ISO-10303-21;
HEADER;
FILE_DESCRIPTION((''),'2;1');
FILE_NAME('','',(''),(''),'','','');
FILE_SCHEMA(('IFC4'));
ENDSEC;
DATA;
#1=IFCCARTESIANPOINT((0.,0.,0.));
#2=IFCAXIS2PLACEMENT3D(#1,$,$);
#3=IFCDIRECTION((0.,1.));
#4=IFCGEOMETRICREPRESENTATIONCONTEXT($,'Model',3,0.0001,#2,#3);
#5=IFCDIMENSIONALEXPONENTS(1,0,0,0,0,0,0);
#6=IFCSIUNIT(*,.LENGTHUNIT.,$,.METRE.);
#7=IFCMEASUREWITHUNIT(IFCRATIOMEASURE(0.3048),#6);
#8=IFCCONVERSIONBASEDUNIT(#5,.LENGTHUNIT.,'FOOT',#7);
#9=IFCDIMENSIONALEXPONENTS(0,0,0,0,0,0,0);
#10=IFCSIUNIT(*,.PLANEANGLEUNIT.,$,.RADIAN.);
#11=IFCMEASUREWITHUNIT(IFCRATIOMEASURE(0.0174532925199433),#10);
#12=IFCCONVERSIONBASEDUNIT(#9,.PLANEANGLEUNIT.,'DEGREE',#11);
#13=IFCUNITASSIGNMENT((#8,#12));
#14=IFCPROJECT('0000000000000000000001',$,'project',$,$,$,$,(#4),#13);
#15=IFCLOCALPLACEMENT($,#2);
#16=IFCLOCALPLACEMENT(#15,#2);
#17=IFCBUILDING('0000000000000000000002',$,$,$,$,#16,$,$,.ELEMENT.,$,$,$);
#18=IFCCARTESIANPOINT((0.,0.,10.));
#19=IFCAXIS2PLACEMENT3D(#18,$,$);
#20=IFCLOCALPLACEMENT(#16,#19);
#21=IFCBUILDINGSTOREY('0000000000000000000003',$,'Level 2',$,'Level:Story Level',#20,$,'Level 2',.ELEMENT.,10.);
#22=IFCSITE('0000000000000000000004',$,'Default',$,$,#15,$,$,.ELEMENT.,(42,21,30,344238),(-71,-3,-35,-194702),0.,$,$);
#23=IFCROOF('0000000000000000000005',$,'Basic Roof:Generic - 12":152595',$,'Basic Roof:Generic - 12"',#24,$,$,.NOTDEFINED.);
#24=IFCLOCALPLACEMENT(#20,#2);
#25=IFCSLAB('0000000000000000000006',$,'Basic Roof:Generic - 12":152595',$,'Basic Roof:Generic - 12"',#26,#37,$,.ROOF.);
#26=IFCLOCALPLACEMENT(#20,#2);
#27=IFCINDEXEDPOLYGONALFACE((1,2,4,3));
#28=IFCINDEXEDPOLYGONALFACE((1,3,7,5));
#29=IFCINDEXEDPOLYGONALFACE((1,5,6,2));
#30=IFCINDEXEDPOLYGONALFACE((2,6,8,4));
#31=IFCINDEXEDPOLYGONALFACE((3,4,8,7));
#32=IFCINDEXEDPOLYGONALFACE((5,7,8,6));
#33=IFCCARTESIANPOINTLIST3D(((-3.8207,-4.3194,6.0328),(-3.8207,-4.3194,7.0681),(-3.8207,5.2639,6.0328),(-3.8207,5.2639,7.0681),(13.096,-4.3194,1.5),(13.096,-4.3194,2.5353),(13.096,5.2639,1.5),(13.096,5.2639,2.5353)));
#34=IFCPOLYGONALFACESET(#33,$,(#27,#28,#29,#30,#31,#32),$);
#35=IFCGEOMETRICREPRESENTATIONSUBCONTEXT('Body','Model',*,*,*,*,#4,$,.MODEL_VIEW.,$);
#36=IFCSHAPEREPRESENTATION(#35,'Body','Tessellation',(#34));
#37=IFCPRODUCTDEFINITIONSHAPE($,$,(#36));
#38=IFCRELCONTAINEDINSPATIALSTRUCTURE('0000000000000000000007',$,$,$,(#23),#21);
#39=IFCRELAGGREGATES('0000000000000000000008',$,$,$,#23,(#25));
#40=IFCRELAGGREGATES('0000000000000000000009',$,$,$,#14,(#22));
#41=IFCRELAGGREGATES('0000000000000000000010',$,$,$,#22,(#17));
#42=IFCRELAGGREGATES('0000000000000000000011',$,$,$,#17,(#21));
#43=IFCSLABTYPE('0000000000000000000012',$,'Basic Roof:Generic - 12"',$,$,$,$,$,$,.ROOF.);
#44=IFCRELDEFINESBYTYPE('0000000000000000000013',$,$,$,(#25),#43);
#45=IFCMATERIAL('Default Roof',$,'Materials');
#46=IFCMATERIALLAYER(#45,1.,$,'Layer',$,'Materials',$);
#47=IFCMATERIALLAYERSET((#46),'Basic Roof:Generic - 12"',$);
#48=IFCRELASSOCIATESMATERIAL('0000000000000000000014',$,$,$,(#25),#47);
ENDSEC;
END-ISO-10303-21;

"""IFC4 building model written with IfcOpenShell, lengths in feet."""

from ifc_helpers import new_model, entity, si_unit, converted_unit, direction, frame, origin, origin_2d_with_axis, place, context, subcontext, project, spatial, rectangle, extrude, material, layer, layer_set, type_object, element, aggregate, save


model = new_model("IFC4")

# Units and contexts
model_context = context("Model", 3, precision=0.0001, world=origin(), true_north=direction((0.0, 1.0)))
body_context = subcontext(model_context, "Body", "Model", "MODEL_VIEW")
ifc_project = project(units=[converted_unit("LENGTHUNIT", "FOOT", entity("IfcRatioMeasure", 0.3048), si_unit("LENGTHUNIT", "METRE"), dimensions=[1, 0, 0, 0, 0, 0, 0]), converted_unit("PLANEANGLEUNIT", "DEGREE", entity("IfcRatioMeasure", 0.0174532925199433), si_unit("PLANEANGLEUNIT", "RADIAN"), dimensions=[0, 0, 0, 0, 0, 0, 0])], contexts=[model_context])

# Site, building, storey
site_placement = place(None, origin())
site = spatial("IfcSite", under=ifc_project, at=site_placement, Name="Default", CompositionType="ELEMENT", RefLatitude=(42, 21, 30, 344238), RefLongitude=(-71, -3, -35, -194702), RefElevation=0.0)
building_placement = place(site_placement, origin())
building = spatial("IfcBuilding", under=site, at=building_placement, CompositionType="ELEMENT")
storey_placement = place(building_placement, frame((0.0, 0.0, 10.0)))
storey = spatial("IfcBuildingStorey", under=building, at=storey_placement, Name="Level 2", ObjectType="Level:Story Level", LongName="Level 2", CompositionType="ELEMENT", Elevation=10.0)

# Roof, slab
roof_placement = place(storey_placement, frame((-3.8207, -4.3194, 1.5)))
roof = element("IfcRoof", 1, at=roof_placement, inside=storey, Name="Basic Roof:Generic - 12\":152595", ObjectType="Basic Roof:Generic - 12\"", PredefinedType="NOTDEFINED")
ifc_material = material(Name="Default Roof", Category="Materials")
ifc_layer = layer(ifc_material, 1.0, Name="Layer", Category="Materials")
ifc_layer_set = layer_set([ifc_layer], Name="Basic Roof:Generic - 12\"")
slab_type = type_object("IfcSlabType", Name="Basic Roof:Generic - 12\"", PredefinedType="ROOF")
slab_placement = place(roof_placement, origin())
slab = element("IfcSlab", 2, at=slab_placement, type_object=slab_type, material=ifc_layer_set, Name="Basic Roof:Generic - 12\":152595", ObjectType="Basic Roof:Generic - 12\"", PredefinedType="ROOF", context=body_context, shape_type="SweptSolid", body=[
    extrude(rectangle(XDim=17.5134, YDim=9.5833, at=origin_2d_with_axis()), frame((8.4583, 4.7917, 2.2664), z_axis=(0.258819, 0.0, 0.965926), x_axis=(0.965926, 0.0, -0.258819)), (-0.258819, 0.0, 0.965926), 1.0353),
])
aggregate(roof, [slab])

save(model, "model.ifc")
